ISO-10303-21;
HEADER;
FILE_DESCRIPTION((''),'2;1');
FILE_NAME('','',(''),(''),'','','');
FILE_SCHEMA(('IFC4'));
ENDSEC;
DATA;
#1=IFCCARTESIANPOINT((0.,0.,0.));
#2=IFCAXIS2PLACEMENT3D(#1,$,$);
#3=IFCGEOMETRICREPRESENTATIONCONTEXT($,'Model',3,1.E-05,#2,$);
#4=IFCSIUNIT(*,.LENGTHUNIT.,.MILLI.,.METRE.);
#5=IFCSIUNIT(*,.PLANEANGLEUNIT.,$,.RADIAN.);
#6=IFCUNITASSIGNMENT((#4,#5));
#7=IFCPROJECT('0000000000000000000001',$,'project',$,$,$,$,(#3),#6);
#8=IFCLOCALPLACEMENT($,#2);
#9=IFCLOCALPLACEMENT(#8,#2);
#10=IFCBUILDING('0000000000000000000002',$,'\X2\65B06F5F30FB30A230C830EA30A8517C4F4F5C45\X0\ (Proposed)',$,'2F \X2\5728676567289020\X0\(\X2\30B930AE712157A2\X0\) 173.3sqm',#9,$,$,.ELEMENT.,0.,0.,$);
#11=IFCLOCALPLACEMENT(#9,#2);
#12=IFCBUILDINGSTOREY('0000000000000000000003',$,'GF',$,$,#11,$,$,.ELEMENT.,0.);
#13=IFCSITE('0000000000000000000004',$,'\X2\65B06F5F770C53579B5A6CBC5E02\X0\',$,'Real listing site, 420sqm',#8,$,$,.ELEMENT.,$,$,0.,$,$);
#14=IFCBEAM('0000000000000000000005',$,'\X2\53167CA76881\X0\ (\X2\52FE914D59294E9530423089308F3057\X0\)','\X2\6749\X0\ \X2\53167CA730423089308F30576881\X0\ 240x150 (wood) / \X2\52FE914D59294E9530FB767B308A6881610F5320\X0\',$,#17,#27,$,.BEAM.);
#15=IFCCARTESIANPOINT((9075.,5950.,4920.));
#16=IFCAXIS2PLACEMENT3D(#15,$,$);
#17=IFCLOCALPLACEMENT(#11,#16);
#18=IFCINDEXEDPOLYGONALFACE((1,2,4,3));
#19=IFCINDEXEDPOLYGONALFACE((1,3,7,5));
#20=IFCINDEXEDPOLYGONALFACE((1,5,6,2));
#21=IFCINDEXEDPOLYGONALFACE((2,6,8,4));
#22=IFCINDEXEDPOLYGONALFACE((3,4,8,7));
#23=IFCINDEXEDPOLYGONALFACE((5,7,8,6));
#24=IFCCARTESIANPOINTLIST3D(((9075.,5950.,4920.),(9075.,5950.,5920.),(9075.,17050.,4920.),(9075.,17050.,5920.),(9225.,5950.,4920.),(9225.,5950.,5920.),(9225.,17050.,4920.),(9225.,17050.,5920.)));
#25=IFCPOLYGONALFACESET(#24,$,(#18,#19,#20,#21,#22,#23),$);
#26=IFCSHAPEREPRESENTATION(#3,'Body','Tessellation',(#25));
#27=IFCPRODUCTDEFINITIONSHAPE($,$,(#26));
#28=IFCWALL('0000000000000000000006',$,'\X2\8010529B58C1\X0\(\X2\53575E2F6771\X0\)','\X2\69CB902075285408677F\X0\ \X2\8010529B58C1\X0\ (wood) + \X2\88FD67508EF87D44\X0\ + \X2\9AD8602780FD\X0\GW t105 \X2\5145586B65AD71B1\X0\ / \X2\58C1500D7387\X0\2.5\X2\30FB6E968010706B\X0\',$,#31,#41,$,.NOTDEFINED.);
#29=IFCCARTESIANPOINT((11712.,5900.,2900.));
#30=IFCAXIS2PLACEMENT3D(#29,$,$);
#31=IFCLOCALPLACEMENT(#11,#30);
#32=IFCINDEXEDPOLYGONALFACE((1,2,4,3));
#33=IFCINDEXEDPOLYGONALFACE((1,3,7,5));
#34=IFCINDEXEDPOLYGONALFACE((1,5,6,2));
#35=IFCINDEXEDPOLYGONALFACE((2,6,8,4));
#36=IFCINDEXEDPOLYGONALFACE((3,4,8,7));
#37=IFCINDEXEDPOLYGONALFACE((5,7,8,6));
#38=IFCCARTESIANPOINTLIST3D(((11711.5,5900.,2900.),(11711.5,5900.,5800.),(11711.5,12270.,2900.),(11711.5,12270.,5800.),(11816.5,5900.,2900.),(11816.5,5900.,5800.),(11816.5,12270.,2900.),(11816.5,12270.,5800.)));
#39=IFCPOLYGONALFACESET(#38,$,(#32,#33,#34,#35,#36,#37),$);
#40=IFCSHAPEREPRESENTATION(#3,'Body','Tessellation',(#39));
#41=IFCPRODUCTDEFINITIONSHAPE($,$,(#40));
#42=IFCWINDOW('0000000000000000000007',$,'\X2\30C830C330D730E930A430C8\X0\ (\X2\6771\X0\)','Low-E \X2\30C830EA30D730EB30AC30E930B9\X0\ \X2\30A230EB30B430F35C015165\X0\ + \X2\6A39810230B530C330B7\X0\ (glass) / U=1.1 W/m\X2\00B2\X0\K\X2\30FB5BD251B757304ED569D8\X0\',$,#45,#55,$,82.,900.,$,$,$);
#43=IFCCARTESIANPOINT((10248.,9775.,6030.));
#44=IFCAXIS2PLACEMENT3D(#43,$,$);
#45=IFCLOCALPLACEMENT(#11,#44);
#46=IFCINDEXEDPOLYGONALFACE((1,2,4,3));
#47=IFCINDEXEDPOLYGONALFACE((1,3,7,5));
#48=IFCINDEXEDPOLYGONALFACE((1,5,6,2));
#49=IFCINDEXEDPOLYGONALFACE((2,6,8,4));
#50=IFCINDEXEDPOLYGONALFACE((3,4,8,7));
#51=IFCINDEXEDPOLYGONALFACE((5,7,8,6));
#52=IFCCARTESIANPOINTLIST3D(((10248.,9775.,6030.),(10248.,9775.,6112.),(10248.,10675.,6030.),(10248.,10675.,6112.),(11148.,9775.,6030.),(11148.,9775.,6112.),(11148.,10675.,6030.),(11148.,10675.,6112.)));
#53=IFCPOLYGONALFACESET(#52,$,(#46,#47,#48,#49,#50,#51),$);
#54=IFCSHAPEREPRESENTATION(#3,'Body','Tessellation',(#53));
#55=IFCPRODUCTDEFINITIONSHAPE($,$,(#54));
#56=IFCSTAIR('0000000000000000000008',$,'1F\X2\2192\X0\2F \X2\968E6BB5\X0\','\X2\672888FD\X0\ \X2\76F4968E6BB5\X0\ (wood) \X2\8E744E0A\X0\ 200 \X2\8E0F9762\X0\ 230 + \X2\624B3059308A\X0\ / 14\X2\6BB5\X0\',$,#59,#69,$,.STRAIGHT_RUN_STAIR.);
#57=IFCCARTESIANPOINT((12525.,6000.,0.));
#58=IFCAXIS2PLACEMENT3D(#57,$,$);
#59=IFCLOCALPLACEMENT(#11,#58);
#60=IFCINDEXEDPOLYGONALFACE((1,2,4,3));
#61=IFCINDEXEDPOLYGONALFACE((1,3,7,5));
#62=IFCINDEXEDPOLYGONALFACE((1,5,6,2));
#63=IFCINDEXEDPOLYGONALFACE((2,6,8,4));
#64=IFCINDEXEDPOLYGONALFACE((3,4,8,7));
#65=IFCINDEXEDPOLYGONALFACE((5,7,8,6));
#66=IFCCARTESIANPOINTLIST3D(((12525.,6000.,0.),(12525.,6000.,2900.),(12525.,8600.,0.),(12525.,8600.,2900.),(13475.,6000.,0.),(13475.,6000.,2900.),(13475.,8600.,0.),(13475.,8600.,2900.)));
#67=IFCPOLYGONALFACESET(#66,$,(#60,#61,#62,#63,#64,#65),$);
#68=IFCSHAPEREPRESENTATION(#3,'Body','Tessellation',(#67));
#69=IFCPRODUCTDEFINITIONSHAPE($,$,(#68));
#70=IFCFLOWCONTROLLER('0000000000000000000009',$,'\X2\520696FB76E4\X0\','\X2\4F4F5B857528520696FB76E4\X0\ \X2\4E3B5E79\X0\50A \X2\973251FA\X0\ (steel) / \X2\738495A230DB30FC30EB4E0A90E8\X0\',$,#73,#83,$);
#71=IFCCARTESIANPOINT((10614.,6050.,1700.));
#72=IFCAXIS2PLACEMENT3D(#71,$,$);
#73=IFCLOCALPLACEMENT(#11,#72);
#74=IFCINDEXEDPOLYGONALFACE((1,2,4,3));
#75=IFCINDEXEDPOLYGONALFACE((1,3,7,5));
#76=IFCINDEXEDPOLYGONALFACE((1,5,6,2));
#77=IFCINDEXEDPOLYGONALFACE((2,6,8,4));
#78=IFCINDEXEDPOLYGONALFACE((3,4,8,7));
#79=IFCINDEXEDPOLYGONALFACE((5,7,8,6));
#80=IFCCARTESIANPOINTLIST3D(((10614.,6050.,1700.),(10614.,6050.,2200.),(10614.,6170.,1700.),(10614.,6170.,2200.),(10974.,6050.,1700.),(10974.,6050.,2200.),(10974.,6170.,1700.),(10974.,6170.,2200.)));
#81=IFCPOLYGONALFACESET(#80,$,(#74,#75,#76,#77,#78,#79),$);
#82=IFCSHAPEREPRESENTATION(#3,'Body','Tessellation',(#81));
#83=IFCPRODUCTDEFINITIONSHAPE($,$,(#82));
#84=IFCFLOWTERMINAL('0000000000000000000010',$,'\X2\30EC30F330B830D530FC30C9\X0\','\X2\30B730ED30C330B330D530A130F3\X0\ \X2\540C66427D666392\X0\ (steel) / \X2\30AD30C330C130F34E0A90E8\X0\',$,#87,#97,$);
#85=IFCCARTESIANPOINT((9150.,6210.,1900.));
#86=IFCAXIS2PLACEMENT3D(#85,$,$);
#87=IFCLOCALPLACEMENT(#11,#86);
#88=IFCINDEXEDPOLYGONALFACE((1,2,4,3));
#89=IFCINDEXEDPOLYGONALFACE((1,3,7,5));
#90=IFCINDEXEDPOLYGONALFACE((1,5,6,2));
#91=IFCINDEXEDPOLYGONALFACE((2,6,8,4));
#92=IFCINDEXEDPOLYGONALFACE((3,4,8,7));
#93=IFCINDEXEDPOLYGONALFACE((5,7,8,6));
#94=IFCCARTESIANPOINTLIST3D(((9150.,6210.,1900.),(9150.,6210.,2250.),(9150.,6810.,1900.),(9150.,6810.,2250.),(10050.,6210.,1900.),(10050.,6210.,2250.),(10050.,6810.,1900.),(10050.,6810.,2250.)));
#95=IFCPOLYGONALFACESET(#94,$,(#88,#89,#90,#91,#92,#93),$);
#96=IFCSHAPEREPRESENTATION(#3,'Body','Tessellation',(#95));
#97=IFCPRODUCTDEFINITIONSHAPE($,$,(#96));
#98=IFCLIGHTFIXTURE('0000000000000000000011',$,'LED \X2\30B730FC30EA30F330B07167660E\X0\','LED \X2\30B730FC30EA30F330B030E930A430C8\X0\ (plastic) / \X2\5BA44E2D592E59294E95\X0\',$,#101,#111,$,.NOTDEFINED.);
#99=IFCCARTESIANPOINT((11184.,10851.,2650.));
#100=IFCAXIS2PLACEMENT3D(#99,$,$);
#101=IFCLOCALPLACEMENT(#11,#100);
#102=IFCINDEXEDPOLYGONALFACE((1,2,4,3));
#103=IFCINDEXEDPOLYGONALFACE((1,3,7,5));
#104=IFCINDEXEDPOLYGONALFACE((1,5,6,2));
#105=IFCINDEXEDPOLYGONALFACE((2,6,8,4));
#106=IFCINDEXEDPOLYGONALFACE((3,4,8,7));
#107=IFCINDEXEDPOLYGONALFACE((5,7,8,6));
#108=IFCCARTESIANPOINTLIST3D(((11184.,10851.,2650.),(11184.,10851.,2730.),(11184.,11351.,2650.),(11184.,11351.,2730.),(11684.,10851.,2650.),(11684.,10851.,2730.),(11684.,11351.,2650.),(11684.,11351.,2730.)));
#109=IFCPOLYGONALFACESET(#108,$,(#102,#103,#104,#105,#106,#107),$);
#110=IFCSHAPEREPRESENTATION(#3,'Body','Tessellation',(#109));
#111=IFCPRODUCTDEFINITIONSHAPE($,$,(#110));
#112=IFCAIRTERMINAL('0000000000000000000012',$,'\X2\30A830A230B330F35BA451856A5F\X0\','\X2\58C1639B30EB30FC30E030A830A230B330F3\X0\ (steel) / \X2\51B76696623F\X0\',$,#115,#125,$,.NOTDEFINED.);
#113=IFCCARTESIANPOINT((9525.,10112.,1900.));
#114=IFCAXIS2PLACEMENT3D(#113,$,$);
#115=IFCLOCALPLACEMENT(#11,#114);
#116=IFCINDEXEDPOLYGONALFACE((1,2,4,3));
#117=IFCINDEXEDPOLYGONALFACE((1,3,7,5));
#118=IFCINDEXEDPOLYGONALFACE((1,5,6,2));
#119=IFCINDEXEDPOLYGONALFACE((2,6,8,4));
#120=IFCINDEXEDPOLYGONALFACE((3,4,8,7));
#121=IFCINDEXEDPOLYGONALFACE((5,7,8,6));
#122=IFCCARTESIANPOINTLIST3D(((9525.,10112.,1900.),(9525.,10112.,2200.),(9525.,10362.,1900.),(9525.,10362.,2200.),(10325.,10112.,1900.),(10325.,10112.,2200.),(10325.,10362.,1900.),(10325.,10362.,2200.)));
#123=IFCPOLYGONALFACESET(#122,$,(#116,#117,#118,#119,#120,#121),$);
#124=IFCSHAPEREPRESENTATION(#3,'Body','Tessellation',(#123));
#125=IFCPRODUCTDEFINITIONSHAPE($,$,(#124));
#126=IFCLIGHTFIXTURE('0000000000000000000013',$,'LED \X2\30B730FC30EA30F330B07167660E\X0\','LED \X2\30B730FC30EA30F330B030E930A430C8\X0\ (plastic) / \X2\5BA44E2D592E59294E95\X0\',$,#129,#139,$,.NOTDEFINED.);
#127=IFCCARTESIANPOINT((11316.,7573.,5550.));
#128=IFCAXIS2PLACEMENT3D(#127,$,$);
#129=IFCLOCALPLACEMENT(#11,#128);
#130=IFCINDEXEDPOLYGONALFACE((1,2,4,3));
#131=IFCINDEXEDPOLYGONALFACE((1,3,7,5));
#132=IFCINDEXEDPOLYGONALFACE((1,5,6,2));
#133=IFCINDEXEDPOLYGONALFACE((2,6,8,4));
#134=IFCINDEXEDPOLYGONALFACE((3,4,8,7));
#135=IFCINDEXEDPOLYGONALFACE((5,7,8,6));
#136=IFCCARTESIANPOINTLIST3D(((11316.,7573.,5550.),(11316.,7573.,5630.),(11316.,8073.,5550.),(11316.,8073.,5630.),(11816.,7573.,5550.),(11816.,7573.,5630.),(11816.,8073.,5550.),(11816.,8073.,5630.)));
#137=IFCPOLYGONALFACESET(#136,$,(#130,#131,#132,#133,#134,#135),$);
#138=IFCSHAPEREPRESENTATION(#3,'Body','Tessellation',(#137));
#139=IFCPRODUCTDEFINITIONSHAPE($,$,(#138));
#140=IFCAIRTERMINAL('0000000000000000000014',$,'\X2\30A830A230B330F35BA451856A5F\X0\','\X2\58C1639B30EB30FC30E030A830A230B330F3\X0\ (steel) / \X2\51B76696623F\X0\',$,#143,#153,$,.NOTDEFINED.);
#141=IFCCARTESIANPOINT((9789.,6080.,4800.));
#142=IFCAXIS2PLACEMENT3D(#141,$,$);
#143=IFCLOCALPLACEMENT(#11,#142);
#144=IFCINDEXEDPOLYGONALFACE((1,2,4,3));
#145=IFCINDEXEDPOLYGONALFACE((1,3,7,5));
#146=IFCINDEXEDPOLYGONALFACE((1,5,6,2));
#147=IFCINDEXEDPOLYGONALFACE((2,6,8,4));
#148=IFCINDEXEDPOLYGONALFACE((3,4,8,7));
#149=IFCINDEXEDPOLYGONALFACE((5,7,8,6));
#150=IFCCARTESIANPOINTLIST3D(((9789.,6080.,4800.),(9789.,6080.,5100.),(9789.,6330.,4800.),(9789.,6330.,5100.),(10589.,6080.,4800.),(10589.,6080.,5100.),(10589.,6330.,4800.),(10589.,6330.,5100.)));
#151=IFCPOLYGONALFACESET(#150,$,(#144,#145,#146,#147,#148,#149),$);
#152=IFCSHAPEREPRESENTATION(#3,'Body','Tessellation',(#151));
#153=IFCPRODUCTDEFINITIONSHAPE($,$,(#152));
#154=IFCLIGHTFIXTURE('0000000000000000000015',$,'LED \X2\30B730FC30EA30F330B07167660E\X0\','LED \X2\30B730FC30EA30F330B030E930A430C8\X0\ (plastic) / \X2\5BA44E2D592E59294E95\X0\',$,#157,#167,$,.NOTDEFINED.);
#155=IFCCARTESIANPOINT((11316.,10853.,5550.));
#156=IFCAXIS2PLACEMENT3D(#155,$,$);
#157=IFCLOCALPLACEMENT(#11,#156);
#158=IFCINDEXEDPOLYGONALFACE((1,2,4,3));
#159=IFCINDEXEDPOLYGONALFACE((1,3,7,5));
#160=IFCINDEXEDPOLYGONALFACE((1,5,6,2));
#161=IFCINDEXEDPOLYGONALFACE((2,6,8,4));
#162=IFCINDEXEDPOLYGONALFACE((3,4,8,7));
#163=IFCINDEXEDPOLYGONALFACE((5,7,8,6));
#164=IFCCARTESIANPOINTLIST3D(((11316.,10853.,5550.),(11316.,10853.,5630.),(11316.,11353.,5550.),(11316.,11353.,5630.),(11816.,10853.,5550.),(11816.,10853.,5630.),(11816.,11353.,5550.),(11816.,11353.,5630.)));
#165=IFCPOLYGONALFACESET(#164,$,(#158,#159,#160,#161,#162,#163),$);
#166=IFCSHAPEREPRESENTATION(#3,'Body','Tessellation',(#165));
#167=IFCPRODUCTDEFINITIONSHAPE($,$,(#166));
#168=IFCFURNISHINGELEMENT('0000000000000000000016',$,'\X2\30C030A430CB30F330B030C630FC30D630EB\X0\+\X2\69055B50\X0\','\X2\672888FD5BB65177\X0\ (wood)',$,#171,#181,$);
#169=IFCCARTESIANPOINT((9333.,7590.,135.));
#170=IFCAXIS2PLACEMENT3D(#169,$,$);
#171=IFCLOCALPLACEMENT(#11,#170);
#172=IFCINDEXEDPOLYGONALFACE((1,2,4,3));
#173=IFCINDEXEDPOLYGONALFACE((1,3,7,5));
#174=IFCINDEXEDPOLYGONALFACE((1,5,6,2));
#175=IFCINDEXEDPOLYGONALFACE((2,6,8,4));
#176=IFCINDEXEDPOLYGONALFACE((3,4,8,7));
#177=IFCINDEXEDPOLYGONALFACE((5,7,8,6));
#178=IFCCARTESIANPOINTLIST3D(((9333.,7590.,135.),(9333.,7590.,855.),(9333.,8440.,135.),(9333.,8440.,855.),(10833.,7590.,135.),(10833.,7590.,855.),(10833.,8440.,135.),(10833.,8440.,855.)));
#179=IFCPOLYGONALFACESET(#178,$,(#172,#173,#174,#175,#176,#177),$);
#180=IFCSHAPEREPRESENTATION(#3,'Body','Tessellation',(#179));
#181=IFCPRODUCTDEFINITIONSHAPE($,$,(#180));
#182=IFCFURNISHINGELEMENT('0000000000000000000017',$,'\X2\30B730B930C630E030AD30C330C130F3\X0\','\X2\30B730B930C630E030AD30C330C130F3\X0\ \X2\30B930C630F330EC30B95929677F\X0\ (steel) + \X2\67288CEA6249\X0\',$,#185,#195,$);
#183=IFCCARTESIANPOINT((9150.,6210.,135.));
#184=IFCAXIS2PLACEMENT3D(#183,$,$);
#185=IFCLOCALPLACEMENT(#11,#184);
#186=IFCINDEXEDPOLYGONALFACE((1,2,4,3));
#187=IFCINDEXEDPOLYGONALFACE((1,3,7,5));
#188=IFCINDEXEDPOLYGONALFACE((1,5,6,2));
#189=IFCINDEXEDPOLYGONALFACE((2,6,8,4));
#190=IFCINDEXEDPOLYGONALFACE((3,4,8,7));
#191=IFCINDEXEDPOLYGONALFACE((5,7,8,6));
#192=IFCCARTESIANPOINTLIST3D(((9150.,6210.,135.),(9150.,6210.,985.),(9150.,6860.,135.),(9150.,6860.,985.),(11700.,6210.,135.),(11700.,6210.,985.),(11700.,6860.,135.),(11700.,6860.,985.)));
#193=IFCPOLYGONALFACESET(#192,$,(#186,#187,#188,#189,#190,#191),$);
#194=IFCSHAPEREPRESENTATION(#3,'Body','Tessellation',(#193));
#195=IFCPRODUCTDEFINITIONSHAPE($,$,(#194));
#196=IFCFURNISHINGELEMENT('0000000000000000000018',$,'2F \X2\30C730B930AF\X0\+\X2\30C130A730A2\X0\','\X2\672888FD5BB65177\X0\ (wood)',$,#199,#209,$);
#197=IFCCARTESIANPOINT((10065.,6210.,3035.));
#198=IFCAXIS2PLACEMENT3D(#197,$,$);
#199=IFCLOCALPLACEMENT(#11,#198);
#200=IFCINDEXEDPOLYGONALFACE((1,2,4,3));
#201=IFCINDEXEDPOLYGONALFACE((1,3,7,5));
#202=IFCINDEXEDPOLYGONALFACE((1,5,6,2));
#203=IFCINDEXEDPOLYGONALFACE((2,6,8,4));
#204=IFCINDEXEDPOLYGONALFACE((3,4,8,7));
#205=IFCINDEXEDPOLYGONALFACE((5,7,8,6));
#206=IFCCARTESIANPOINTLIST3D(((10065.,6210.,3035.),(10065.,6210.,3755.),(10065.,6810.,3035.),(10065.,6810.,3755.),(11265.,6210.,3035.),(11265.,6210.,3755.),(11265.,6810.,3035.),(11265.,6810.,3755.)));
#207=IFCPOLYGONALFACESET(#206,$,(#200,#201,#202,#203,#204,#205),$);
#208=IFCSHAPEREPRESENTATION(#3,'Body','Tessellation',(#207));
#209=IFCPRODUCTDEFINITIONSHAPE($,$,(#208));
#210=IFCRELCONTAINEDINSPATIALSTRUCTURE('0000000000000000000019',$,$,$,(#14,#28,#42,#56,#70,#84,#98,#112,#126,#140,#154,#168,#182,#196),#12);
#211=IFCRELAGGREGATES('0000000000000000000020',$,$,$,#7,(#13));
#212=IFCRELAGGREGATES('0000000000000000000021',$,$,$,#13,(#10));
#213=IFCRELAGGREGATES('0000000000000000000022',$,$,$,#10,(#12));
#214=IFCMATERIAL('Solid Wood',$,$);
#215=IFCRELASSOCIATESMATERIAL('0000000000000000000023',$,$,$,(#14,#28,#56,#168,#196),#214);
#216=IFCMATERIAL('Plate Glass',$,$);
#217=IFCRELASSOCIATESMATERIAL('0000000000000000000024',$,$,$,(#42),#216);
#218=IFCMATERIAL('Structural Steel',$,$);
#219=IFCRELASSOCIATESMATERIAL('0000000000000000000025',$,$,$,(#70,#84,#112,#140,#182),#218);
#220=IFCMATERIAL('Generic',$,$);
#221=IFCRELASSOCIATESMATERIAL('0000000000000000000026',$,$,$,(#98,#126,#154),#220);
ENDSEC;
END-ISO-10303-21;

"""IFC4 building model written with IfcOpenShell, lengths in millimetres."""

from ifc_helpers import new_model, si_unit, frame, frame_2d, origin, place, context, project, spatial, rectangle, extrude, material, element, save


model = new_model("IFC4")

# Units and contexts
model_context = context("Model", 3, precision=1e-05, world=origin())
ifc_project = project(units=[si_unit("LENGTHUNIT", "METRE", prefix="MILLI"), si_unit("PLANEANGLEUNIT", "RADIAN")], contexts=[model_context])

# Site, building, storey
site_placement = place(None, origin())
site = spatial("IfcSite", under=ifc_project, at=site_placement, Name="新潟県南魚沼市", ObjectType="Real listing site, 420sqm", CompositionType="ELEMENT", RefElevation=0.0)
building_placement = place(site_placement, origin())
building = spatial("IfcBuilding", under=site, at=building_placement, Name="新潟・アトリエ兼住居 (Proposed)", ObjectType="2F 在来木造(スギ無垢) 173.3sqm", CompositionType="ELEMENT", ElevationOfRefHeight=0.0, ElevationOfTerrain=0.0)
storey_placement = place(building_placement, origin())
storey = spatial("IfcBuildingStorey", under=building, at=storey_placement, Name="GF", CompositionType="ELEMENT", Elevation=0.0)

# Shared definitions
ifc_material_1 = material(Name="Solid Wood")

# Beam
beam_placement = place(storey_placement, frame((9075.0, 5950.0, 4920.0)))
element("IfcBeam", 1, at=beam_placement, inside=storey, material=ifc_material_1, Name="化粧梁 (勾配天井あらわし)", Description="杉 化粧あらわし梁 240x150 (wood) / 勾配天井・登り梁意匠", PredefinedType="BEAM", context=model_context, shape_type="SweptSolid", body=[
    extrude(rectangle(XDim=150.0, YDim=11100.0, at=frame_2d((75.0, 5550.0))), frame((9075.0, 5950.0, 4920.0)), (0.0, 0.0, 1.0), 1000.0),
])

# Wall
wall_1_placement = place(storey_placement, frame((11712.0, 5900.0, 2900.0)))
element("IfcWall", 2, at=wall_1_placement, inside=storey, material=ifc_material_1, Name="耐力壁(南帯東)", Description="構造用合板 耐力壁 (wood) + 製材軸組 + 高性能GW t105 充填断熱 / 壁倍率2.5・準耐火", PredefinedType="NOTDEFINED", context=model_context, shape_type="SweptSolid", body=[
    extrude(rectangle(XDim=105.0, YDim=6370.0, at=frame_2d((52.0, 3185.0))), frame((11712.0, 5900.0, 2900.0)), (0.0, 0.0, 1.0), 2900.0),
])

# Window
ifc_material_2 = material(Name="Plate Glass")
window_placement = place(storey_placement, frame((10248.0, 9775.0, 6030.0)))
element("IfcWindow", 3, at=window_placement, inside=storey, material=ifc_material_2, Name="トップライト (東)", Description="Low-E トリプルガラス アルゴン封入 + 樹脂サッシ (glass) / U=1.1 W/m²K・寒冷地仕様", OverallHeight=82.0, OverallWidth=900.0, context=model_context, shape_type="SweptSolid", body=[
    extrude(rectangle(XDim=900.0, YDim=900.0, at=frame_2d((450.0, 450.0))), frame((10248.0, 9775.0, 6030.0)), (0.0, 0.0, 1.0), 82.0),
])

# Stair
stair_placement = place(storey_placement, frame((12525.0, 6000.0, 0.0)))
element("IfcStair", 4, at=stair_placement, inside=storey, material=ifc_material_1, Name="1F→2F 階段", Description="木製 直階段 (wood) 蹴上 200 踏面 230 + 手すり / 14段", PredefinedType="STRAIGHT_RUN_STAIR", context=model_context, shape_type="SweptSolid", body=[
    extrude(rectangle(XDim=950.0, YDim=2600.0, at=frame_2d((475.0, 1300.0))), frame((12525.0, 6000.0, 0.0)), (0.0, 0.0, 1.0), 2900.0),
])

# Flow controller
ifc_material_3 = material(Name="Structural Steel")
flow_controller_placement = place(storey_placement, frame((10614.0, 6050.0, 1700.0)))
element("IfcFlowController", 5, at=flow_controller_placement, inside=storey, material=ifc_material_3, Name="分電盤", Description="住宅用分電盤 主幹50A 露出 (steel) / 玄関ホール上部", context=model_context, shape_type="SweptSolid", body=[
    extrude(rectangle(XDim=360.0, YDim=120.0, at=frame_2d((180.0, 60.0))), frame((10614.0, 6050.0, 1700.0)), (0.0, 0.0, 1.0), 500.0),
])

# Flow terminal
flow_terminal_placement = place(storey_placement, frame((9150.0, 6210.0, 1900.0)))
element("IfcFlowTerminal", 6, at=flow_terminal_placement, inside=storey, material=ifc_material_3, Name="レンジフード", Description="シロッコファン 同時給排 (steel) / キッチン上部", context=model_context, shape_type="SweptSolid", body=[
    extrude(rectangle(XDim=900.0, YDim=600.0, at=frame_2d((450.0, 300.0))), frame((9150.0, 6210.0, 1900.0)), (0.0, 0.0, 1.0), 350.0),
])

# Light fixture
ifc_material_4 = material(Name="Generic")
light_fixture_1_placement = place(storey_placement, frame((11184.0, 10851.0, 2650.0)))
element("IfcLightFixture", 7, at=light_fixture_1_placement, inside=storey, material=ifc_material_4, Name="LED シーリング照明", Description="LED シーリングライト (plastic) / 室中央天井", PredefinedType="NOTDEFINED", context=model_context, shape_type="SweptSolid", body=[
    extrude(rectangle(XDim=500.0, YDim=500.0, at=frame_2d((250.0, 250.0))), frame((11184.0, 10851.0, 2650.0)), (0.0, 0.0, 1.0), 80.0),
])

# Air terminal
air_terminal_1_placement = place(storey_placement, frame((9525.0, 10112.0, 1900.0)))
element("IfcAirTerminal", 8, at=air_terminal_1_placement, inside=storey, material=ifc_material_3, Name="エアコン室内機", Description="壁掛ルームエアコン (steel) / 冷暖房", PredefinedType="NOTDEFINED", context=model_context, shape_type="SweptSolid", body=[
    extrude(rectangle(XDim=800.0, YDim=250.0, at=frame_2d((400.0, 125.0))), frame((9525.0, 10112.0, 1900.0)), (0.0, 0.0, 1.0), 300.0),
])

# Light fixture
light_fixture_2_placement = place(storey_placement, frame((11316.0, 7573.0, 5550.0)))
element("IfcLightFixture", 9, at=light_fixture_2_placement, inside=storey, material=ifc_material_4, Name="LED シーリング照明", Description="LED シーリングライト (plastic) / 室中央天井", PredefinedType="NOTDEFINED", context=model_context, shape_type="SweptSolid", body=[
    extrude(rectangle(XDim=500.0, YDim=500.0, at=frame_2d((250.0, 250.0))), frame((11316.0, 7573.0, 5550.0)), (0.0, 0.0, 1.0), 80.0),
])

# Air terminal
air_terminal_2_placement = place(storey_placement, frame((9789.0, 6080.0, 4800.0)))
element("IfcAirTerminal", 10, at=air_terminal_2_placement, inside=storey, material=ifc_material_3, Name="エアコン室内機", Description="壁掛ルームエアコン (steel) / 冷暖房", PredefinedType="NOTDEFINED", context=model_context, shape_type="SweptSolid", body=[
    extrude(rectangle(XDim=800.0, YDim=250.0, at=frame_2d((400.0, 125.0))), frame((9789.0, 6080.0, 4800.0)), (0.0, 0.0, 1.0), 300.0),
])

# Light fixture
light_fixture_3_placement = place(storey_placement, frame((11316.0, 10853.0, 5550.0)))
element("IfcLightFixture", 11, at=light_fixture_3_placement, inside=storey, material=ifc_material_4, Name="LED シーリング照明", Description="LED シーリングライト (plastic) / 室中央天井", PredefinedType="NOTDEFINED", context=model_context, shape_type="SweptSolid", body=[
    extrude(rectangle(XDim=500.0, YDim=500.0, at=frame_2d((250.0, 250.0))), frame((11316.0, 10853.0, 5550.0)), (0.0, 0.0, 1.0), 80.0),
])

# Furnishing elements
furnishing_1_placement = place(storey_placement, frame((9333.0, 7590.0, 135.0)))
element("IfcFurnishingElement", 12, at=furnishing_1_placement, inside=storey, material=ifc_material_1, Name="ダイニングテーブル+椅子", Description="木製家具 (wood)", context=model_context, shape_type="SweptSolid", body=[
    extrude(rectangle(XDim=1500.0, YDim=850.0, at=frame_2d((750.0, 425.0))), frame((9333.0, 7590.0, 135.0)), (0.0, 0.0, 1.0), 720.0),
])
furnishing_2_placement = place(storey_placement, frame((9150.0, 6210.0, 135.0)))
element("IfcFurnishingElement", 13, at=furnishing_2_placement, inside=storey, material=ifc_material_3, Name="システムキッチン", Description="システムキッチン ステンレス天板 (steel) + 木質扉", context=model_context, shape_type="SweptSolid", body=[
    extrude(rectangle(XDim=2550.0, YDim=650.0, at=frame_2d((1275.0, 325.0))), frame((9150.0, 6210.0, 135.0)), (0.0, 0.0, 1.0), 850.0),
])
furnishing_3_placement = place(storey_placement, frame((10065.0, 6210.0, 3035.0)))
element("IfcFurnishingElement", 14, at=furnishing_3_placement, inside=storey, material=ifc_material_1, Name="2F デスク+チェア", Description="木製家具 (wood)", context=model_context, shape_type="SweptSolid", body=[
    extrude(rectangle(XDim=1200.0, YDim=600.0, at=frame_2d((600.0, 300.0))), frame((10065.0, 6210.0, 3035.0)), (0.0, 0.0, 1.0), 720.0),
])

save(model, "model.ifc")
